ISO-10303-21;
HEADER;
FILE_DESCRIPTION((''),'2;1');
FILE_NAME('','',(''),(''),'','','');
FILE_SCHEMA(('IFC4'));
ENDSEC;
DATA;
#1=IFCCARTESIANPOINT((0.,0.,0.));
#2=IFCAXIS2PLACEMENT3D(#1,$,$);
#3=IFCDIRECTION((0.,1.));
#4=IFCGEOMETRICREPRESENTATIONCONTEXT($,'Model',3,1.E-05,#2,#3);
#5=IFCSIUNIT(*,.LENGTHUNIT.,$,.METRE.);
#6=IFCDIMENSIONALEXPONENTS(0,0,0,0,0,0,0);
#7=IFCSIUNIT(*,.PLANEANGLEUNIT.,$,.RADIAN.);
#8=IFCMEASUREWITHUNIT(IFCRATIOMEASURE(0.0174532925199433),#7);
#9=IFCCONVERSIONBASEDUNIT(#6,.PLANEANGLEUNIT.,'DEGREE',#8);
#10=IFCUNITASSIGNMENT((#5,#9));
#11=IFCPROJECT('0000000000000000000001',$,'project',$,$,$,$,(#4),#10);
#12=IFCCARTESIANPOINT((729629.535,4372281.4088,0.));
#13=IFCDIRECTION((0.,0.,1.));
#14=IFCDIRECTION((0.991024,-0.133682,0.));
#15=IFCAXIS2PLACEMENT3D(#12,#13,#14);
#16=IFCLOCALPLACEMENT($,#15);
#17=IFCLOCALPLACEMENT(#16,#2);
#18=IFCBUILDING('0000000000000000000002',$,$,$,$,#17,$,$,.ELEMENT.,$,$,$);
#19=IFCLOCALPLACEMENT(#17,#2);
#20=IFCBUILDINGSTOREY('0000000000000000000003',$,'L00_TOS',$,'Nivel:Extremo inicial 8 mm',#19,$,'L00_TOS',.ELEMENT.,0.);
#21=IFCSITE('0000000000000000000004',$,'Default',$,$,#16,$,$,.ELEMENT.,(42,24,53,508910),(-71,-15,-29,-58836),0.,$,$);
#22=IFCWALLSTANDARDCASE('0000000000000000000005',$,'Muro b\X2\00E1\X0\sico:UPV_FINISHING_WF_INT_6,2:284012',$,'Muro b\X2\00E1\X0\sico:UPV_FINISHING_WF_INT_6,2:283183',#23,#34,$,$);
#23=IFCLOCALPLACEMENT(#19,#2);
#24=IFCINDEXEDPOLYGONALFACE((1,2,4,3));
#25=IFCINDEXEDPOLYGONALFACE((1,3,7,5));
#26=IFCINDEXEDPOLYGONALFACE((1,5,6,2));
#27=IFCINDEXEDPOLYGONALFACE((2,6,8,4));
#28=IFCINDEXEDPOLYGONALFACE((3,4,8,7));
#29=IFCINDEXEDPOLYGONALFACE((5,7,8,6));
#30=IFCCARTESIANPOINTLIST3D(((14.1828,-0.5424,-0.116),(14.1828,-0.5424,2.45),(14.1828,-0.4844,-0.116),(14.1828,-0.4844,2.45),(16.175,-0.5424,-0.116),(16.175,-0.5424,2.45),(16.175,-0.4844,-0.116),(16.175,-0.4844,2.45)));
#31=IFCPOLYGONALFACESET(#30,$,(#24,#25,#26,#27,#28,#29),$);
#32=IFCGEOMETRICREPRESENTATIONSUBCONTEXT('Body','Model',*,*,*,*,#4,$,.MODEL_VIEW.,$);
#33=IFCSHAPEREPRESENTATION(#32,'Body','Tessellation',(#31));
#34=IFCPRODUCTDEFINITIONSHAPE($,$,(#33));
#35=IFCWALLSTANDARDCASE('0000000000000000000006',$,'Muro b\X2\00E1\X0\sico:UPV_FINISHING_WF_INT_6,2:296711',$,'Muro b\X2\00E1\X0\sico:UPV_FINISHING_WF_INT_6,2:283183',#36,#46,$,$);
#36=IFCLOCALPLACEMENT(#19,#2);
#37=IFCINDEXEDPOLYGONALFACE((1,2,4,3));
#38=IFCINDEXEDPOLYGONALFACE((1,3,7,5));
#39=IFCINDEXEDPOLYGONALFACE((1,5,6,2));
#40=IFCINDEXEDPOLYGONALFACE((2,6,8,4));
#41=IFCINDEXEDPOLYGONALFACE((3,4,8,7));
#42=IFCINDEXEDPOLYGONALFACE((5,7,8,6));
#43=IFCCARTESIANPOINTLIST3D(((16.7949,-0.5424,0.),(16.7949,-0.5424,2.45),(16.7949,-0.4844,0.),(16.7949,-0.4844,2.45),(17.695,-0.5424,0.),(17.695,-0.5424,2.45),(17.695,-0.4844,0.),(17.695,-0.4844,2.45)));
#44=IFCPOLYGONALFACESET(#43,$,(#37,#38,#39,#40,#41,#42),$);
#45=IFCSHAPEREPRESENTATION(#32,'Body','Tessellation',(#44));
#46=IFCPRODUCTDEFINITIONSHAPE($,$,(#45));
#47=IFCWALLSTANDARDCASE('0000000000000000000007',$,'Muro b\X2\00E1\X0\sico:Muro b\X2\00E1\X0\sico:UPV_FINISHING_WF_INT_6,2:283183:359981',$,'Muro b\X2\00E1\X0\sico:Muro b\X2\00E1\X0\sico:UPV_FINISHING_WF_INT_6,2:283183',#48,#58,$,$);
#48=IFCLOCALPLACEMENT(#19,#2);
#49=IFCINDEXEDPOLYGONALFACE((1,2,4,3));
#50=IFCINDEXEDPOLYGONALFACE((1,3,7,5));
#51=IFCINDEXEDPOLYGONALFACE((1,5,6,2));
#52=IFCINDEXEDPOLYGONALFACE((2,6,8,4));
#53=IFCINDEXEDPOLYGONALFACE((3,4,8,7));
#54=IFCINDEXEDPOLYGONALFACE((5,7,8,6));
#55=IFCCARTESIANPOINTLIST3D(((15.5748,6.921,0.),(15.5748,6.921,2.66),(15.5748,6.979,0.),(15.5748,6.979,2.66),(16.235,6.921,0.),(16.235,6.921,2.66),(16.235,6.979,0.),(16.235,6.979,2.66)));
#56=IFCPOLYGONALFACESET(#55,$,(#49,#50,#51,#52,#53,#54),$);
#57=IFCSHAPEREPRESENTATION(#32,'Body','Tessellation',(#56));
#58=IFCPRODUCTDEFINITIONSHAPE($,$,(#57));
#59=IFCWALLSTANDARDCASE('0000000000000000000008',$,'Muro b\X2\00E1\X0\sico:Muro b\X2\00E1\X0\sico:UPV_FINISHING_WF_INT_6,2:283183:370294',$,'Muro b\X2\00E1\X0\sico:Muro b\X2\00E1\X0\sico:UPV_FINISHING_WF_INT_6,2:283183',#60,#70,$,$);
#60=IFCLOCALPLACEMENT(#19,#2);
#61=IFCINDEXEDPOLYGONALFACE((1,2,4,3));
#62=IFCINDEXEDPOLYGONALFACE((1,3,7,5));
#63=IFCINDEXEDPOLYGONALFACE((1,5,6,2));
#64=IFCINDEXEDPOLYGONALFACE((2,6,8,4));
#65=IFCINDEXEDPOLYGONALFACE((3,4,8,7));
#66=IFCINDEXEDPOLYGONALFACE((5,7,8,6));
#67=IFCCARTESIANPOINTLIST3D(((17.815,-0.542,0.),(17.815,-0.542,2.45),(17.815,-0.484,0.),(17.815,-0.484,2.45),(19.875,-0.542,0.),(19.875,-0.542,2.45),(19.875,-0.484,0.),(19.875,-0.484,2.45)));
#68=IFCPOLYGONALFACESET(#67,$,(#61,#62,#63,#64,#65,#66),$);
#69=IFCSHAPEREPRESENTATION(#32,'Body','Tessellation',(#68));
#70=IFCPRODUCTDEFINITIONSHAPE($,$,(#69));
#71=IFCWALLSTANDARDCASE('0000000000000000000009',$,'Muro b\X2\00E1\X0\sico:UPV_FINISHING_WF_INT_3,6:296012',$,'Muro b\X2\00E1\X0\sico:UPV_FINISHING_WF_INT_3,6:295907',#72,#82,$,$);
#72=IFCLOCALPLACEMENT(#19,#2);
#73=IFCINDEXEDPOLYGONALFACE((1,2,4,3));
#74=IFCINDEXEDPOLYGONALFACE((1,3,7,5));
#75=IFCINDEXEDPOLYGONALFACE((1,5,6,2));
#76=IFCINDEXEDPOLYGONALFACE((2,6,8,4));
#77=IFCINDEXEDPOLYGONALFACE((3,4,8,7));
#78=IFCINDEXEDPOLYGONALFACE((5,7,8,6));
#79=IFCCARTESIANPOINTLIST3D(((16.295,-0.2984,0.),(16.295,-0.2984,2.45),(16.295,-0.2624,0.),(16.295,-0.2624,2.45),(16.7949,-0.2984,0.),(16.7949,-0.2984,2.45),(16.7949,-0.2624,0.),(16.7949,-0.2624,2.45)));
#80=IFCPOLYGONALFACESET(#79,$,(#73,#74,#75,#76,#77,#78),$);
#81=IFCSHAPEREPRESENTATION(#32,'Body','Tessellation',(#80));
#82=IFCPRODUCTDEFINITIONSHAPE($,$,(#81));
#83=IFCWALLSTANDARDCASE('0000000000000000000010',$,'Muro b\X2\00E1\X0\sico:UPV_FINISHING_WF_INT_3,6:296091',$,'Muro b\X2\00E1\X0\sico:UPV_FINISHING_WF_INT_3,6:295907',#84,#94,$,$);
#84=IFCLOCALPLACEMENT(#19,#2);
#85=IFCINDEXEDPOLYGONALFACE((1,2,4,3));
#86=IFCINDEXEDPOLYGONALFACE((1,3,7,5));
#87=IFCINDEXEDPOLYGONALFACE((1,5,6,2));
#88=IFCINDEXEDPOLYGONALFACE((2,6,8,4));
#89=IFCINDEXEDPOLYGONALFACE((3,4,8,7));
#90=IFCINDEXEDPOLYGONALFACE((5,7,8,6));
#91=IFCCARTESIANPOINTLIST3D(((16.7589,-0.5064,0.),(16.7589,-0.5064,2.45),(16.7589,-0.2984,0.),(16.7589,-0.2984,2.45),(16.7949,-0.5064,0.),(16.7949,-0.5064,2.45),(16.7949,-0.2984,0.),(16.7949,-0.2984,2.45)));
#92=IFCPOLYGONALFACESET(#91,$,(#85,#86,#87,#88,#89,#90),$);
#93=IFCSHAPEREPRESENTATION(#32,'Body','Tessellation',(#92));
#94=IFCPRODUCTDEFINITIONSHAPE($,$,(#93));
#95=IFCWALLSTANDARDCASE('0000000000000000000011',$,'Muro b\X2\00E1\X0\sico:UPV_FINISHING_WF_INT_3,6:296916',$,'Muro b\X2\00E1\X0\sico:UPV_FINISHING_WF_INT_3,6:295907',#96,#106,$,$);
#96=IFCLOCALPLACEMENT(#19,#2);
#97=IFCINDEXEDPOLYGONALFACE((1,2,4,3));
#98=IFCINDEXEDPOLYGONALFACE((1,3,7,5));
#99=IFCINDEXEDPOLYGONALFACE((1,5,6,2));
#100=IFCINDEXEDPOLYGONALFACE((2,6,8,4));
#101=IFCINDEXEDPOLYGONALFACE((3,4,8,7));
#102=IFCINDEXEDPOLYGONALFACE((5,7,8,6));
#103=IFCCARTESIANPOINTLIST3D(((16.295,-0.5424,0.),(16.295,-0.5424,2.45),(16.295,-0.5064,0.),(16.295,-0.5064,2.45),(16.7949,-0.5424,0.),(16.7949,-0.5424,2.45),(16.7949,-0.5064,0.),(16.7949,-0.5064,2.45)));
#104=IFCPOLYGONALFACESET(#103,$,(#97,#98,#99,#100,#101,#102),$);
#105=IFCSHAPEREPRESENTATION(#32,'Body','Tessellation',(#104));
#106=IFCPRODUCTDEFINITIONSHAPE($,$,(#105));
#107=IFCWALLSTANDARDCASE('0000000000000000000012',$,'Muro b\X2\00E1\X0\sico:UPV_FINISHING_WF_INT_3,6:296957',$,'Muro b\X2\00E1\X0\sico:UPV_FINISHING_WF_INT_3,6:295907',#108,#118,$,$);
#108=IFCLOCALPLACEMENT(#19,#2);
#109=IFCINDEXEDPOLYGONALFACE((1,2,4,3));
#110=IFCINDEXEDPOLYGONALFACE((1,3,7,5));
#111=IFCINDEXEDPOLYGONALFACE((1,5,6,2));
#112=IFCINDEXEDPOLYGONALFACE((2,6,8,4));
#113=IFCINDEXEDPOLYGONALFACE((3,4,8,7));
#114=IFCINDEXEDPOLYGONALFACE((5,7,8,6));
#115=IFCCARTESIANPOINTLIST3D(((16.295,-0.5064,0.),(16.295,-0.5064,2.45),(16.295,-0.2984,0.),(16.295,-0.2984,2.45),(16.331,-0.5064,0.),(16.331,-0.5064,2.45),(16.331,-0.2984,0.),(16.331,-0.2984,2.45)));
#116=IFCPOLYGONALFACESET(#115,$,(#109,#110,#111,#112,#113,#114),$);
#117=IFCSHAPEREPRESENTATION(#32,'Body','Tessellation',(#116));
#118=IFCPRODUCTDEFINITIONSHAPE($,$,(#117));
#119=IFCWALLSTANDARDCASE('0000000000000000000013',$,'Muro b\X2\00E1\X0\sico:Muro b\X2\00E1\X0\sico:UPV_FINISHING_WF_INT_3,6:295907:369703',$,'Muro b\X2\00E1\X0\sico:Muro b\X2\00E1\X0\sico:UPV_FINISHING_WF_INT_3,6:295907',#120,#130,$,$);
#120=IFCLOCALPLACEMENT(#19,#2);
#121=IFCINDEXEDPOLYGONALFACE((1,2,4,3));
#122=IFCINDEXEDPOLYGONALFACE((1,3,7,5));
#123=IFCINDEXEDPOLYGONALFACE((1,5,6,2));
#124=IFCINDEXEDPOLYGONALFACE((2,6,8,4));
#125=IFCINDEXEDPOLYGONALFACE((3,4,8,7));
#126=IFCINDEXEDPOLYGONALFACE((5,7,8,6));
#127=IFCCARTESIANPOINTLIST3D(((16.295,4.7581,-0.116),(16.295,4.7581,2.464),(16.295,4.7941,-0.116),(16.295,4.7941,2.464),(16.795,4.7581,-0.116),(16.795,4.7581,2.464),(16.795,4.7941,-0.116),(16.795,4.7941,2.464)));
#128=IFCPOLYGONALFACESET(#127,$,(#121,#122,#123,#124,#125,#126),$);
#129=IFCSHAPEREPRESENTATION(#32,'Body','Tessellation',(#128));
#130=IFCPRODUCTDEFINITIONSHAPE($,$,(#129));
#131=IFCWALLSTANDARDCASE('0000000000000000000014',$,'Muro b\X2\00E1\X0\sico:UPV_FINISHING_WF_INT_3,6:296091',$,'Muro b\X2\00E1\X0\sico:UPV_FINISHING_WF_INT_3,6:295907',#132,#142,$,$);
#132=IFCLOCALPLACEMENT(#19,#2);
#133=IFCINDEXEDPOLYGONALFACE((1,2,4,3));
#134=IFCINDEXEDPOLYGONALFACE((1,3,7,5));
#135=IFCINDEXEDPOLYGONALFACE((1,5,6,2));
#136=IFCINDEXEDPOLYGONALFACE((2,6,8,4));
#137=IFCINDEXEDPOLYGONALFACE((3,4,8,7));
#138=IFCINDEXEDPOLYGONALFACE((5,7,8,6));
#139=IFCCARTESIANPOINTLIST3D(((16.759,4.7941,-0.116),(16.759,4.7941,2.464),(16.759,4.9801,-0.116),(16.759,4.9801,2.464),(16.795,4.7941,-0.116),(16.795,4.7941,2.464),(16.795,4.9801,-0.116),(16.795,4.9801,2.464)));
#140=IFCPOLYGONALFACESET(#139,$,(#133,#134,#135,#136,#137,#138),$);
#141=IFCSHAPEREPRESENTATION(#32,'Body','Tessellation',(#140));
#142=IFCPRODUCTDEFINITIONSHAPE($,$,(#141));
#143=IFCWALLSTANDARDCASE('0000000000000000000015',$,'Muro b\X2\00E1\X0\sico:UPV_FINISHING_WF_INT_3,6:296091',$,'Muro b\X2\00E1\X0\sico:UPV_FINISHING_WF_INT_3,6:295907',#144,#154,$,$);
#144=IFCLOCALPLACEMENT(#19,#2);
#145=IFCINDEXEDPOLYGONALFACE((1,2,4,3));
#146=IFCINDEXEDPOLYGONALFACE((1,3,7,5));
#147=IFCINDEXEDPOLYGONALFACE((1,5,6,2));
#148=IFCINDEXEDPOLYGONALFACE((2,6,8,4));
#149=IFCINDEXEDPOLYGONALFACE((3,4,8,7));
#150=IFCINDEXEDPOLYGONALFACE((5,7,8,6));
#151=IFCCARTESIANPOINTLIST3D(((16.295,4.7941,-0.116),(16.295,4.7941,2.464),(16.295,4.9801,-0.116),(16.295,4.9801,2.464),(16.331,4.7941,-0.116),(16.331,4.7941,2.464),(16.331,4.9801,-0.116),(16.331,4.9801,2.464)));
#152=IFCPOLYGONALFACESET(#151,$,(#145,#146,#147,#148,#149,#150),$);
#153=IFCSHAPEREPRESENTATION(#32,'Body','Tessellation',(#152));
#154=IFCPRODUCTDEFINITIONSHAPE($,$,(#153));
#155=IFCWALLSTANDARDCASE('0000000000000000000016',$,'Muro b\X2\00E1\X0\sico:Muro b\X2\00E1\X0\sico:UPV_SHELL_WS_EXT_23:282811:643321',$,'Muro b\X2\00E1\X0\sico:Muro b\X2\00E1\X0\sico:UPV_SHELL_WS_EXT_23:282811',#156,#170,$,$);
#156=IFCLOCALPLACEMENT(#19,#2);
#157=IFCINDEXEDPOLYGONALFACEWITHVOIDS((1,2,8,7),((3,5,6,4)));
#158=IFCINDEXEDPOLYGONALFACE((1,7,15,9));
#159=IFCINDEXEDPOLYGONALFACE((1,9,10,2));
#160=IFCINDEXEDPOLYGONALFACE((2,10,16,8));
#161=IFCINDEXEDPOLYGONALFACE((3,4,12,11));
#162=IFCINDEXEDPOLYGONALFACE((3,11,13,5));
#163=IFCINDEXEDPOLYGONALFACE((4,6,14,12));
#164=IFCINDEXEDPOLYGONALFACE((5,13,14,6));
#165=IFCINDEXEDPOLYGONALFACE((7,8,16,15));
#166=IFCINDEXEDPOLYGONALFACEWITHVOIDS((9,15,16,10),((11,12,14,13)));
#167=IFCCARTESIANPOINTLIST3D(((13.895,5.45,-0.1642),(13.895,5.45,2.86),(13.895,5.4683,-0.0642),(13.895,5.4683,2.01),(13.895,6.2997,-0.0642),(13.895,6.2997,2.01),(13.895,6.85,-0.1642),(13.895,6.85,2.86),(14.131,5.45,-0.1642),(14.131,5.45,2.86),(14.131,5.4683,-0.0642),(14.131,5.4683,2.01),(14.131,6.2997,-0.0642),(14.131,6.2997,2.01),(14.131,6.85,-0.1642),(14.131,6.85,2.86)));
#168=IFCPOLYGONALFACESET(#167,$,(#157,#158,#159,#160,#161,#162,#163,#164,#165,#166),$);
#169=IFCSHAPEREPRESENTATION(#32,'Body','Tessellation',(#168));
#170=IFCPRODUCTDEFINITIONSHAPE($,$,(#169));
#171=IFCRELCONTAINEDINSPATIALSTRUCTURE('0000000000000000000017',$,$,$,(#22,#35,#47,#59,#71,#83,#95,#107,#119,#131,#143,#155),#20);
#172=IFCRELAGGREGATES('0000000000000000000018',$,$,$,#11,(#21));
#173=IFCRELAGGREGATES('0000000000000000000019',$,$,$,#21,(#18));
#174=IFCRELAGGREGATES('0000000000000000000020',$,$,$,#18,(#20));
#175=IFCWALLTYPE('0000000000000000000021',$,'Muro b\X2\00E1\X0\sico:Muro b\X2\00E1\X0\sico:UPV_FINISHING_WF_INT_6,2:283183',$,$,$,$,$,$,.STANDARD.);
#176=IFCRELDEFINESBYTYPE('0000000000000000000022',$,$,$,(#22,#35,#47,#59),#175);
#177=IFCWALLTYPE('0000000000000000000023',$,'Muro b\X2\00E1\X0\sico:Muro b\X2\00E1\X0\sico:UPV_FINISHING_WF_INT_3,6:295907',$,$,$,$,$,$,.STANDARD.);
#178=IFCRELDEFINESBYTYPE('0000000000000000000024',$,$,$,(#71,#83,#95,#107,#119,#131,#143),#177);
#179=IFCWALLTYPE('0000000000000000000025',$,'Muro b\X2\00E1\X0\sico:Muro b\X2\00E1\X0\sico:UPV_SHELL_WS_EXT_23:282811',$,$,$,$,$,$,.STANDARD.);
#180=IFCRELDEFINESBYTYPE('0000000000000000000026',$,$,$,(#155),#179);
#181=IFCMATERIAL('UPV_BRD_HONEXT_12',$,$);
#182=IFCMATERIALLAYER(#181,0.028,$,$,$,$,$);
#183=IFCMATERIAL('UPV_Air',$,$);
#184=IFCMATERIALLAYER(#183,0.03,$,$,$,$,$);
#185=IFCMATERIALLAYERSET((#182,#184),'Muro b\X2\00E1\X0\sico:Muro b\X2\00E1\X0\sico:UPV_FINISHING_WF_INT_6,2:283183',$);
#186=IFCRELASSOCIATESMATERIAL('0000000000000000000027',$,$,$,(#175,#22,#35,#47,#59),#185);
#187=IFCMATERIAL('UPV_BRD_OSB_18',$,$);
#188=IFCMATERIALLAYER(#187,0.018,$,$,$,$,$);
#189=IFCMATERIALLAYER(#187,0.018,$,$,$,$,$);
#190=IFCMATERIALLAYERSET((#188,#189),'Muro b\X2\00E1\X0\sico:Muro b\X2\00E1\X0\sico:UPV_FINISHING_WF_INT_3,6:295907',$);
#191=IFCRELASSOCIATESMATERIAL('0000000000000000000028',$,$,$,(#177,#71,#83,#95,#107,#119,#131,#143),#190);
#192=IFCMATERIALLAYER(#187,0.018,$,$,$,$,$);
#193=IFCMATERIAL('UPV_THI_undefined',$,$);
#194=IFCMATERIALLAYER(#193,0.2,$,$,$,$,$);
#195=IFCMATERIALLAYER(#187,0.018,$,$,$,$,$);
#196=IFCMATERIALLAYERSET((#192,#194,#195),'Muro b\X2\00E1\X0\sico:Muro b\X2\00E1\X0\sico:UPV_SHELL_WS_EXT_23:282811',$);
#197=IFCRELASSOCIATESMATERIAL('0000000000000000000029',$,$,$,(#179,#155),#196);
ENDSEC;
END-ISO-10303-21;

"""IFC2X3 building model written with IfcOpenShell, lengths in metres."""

from ifc_helpers import new_model, entity, si_unit, converted_unit, direction, frame, frame_2d, origin, place, context, subcontext, project, spatial, rectangle, extrude, material, layer, layer_set, layer_usage, type_object, element, save


model = new_model("IFC2X3")

# Units and contexts
model_context = context("Model", 3, precision=1e-05, world=origin(), true_north=direction((0.0, 1.0)))
body_context = subcontext(model_context, "Body", "Model", "MODEL_VIEW")
ifc_project = project(units=[si_unit("LENGTHUNIT", "METRE"), converted_unit("PLANEANGLEUNIT", "DEGREE", entity("IfcRatioMeasure", 0.0174532925199433), si_unit("PLANEANGLEUNIT", "RADIAN"), dimensions=[0, 0, 0, 0, 0, 0, 0])], contexts=[model_context])

# Site, building, storey
site_placement = place(None, frame((729629.535, 4372281.4088, 0.0), z_axis=(0.0, 0.0, 1.0), x_axis=(0.991024, -0.133682, 0.0)))
site = spatial("IfcSite", under=ifc_project, at=site_placement, Name="Default", CompositionType="ELEMENT", RefLatitude=(42, 24, 53, 508910), RefLongitude=(-71, -15, -29, -58836), RefElevation=0.0)
building_placement = place(site_placement, origin())
building = spatial("IfcBuilding", under=site, at=building_placement, CompositionType="ELEMENT")
storey_placement = place(building_placement, origin())
storey = spatial("IfcBuildingStorey", under=building, at=storey_placement, Name="L00_TOS", ObjectType="Nivel:Extremo inicial 8 mm", LongName="L00_TOS", CompositionType="ELEMENT", Elevation=0.0)

# Walls
ifc_material_1 = material(Name="UPV_BRD_HONEXT_12")
ifc_layer_1 = layer(ifc_material_1, 0.028)
ifc_material_2 = material(Name="UPV_Air")
ifc_layer_2 = layer(ifc_material_2, 0.03)
ifc_layer_set_1 = layer_set([ifc_layer_1, ifc_layer_2], Name="Muro básico:Muro básico:UPV_FINISHING_WF_INT_6,2:283183")
ifc_layer_usage_1 = layer_usage(ifc_layer_set_1, "AXIS2", "NEGATIVE", 0.029)
wall_type_1 = type_object("IfcWallType", Name="Muro básico:Muro básico:UPV_FINISHING_WF_INT_6,2:283183", PredefinedType="STANDARD", material=ifc_layer_set_1)
wall_1_placement = place(storey_placement, frame((14.1828, -0.5134, -0.116)))
element("IfcWallStandardCase", 1, at=wall_1_placement, inside=storey, type_object=wall_type_1, material=ifc_layer_usage_1, Name="Muro básico:UPV_FINISHING_WF_INT_6,2:284012", ObjectType="Muro básico:UPV_FINISHING_WF_INT_6,2:283183", context=body_context, shape_type="SweptSolid", body=[
    extrude(rectangle(XDim=1.9922, YDim=0.058, at=frame_2d((0.9961, 0.0), x_axis=(-1.0, 0.0))), origin(), (0.0, 0.0, 1.0), 2.566),
])
ifc_layer_usage_2 = layer_usage(ifc_layer_set_1, "AXIS2", "NEGATIVE", 0.029)
wall_2_placement = place(storey_placement, frame((16.7949, -0.5134, 0.0)))
element("IfcWallStandardCase", 2, at=wall_2_placement, inside=storey, type_object=wall_type_1, material=ifc_layer_usage_2, Name="Muro básico:UPV_FINISHING_WF_INT_6,2:296711", ObjectType="Muro básico:UPV_FINISHING_WF_INT_6,2:283183", context=body_context, shape_type="SweptSolid", body=[
    extrude(rectangle(XDim=0.9, YDim=0.058, at=frame_2d((0.45, 0.0), x_axis=(-1.0, 0.0))), origin(), (0.0, 0.0, 1.0), 2.45),
])
ifc_layer_usage_3 = layer_usage(ifc_layer_set_1, "AXIS2", "NEGATIVE", 0.029)
wall_3_placement = place(storey_placement, frame((16.235, 6.95, 0.0), z_axis=(0.0, 0.0, 1.0), x_axis=(-1.0, 0.0, 0.0)))
element("IfcWallStandardCase", 3, at=wall_3_placement, inside=storey, type_object=wall_type_1, material=ifc_layer_usage_3, Name="Muro básico:Muro básico:UPV_FINISHING_WF_INT_6,2:283183:359981", ObjectType="Muro básico:Muro básico:UPV_FINISHING_WF_INT_6,2:283183", context=body_context, shape_type="SweptSolid", body=[
    extrude(rectangle(XDim=0.6602, YDim=0.058, at=frame_2d((0.3301, 0.0), x_axis=(-1.0, 0.0))), origin(), (0.0, 0.0, 1.0), 2.66),
])
ifc_layer_usage_4 = layer_usage(ifc_layer_set_1, "AXIS2", "NEGATIVE", 0.029)
wall_4_placement = place(storey_placement, frame((17.815, -0.513, 0.0)))
element("IfcWallStandardCase", 4, at=wall_4_placement, inside=storey, type_object=wall_type_1, material=ifc_layer_usage_4, Name="Muro básico:Muro básico:UPV_FINISHING_WF_INT_6,2:283183:370294", ObjectType="Muro básico:Muro básico:UPV_FINISHING_WF_INT_6,2:283183", context=body_context, shape_type="SweptSolid", body=[
    extrude(rectangle(XDim=2.06, YDim=0.058, at=frame_2d((1.03, 0.0), x_axis=(-1.0, 0.0))), origin(), (0.0, 0.0, 1.0), 2.45),
])
ifc_material_3 = material(Name="UPV_BRD_OSB_18")
ifc_layer_3 = layer(ifc_material_3, 0.018)
ifc_layer_4 = layer(ifc_material_3, 0.018)
ifc_layer_set_2 = layer_set([ifc_layer_3, ifc_layer_4], Name="Muro básico:Muro básico:UPV_FINISHING_WF_INT_3,6:295907")
ifc_layer_usage_5 = layer_usage(ifc_layer_set_2, "AXIS2", "NEGATIVE", 0.018)
wall_type_2 = type_object("IfcWallType", Name="Muro básico:Muro básico:UPV_FINISHING_WF_INT_3,6:295907", PredefinedType="STANDARD", material=ifc_layer_set_2)
wall_5_placement = place(storey_placement, frame((16.295, -0.2804, 0.0)))
element("IfcWallStandardCase", 5, at=wall_5_placement, inside=storey, type_object=wall_type_2, material=ifc_layer_usage_5, Name="Muro básico:UPV_FINISHING_WF_INT_3,6:296012", ObjectType="Muro básico:UPV_FINISHING_WF_INT_3,6:295907", context=body_context, shape_type="SweptSolid", body=[
    extrude(rectangle(XDim=0.5, YDim=0.036, at=frame_2d((0.25, 0.0), x_axis=(-1.0, 0.0))), origin(), (0.0, 0.0, 1.0), 2.45),
])
ifc_layer_usage_6 = layer_usage(ifc_layer_set_2, "AXIS2", "NEGATIVE", 0.018)
wall_6_placement = place(storey_placement, frame((16.7769, -0.2984, 0.0), z_axis=(0.0, 0.0, 1.0), x_axis=(0.0, -1.0, 0.0)))
element("IfcWallStandardCase", 6, at=wall_6_placement, inside=storey, type_object=wall_type_2, material=ifc_layer_usage_6, Name="Muro básico:UPV_FINISHING_WF_INT_3,6:296091", ObjectType="Muro básico:UPV_FINISHING_WF_INT_3,6:295907", context=body_context, shape_type="SweptSolid", body=[
    extrude(rectangle(XDim=0.208, YDim=0.036, at=frame_2d((0.104, 0.0), x_axis=(-1.0, 0.0))), origin(), (0.0, 0.0, 1.0), 2.45),
])
ifc_layer_usage_7 = layer_usage(ifc_layer_set_2, "AXIS2", "NEGATIVE", 0.018)
wall_7_placement = place(storey_placement, frame((16.7949, -0.5244, 0.0), z_axis=(0.0, 0.0, 1.0), x_axis=(-1.0, 0.0, 0.0)))
element("IfcWallStandardCase", 7, at=wall_7_placement, inside=storey, type_object=wall_type_2, material=ifc_layer_usage_7, Name="Muro básico:UPV_FINISHING_WF_INT_3,6:296916", ObjectType="Muro básico:UPV_FINISHING_WF_INT_3,6:295907", context=body_context, shape_type="SweptSolid", body=[
    extrude(rectangle(XDim=0.5, YDim=0.036, at=frame_2d((0.25, 0.0), x_axis=(-1.0, 0.0))), origin(), (0.0, 0.0, 1.0), 2.45),
])
ifc_layer_usage_8 = layer_usage(ifc_layer_set_2, "AXIS2", "NEGATIVE", 0.018)
wall_8_placement = place(storey_placement, frame((16.313, -0.5064, 0.0), z_axis=(0.0, 0.0, 1.0), x_axis=(0.0, 1.0, 0.0)))
element("IfcWallStandardCase", 8, at=wall_8_placement, inside=storey, type_object=wall_type_2, material=ifc_layer_usage_8, Name="Muro básico:UPV_FINISHING_WF_INT_3,6:296957", ObjectType="Muro básico:UPV_FINISHING_WF_INT_3,6:295907", context=body_context, shape_type="SweptSolid", body=[
    extrude(rectangle(XDim=0.208, YDim=0.036, at=frame_2d((0.104, 0.0), x_axis=(-1.0, 0.0))), origin(), (0.0, 0.0, 1.0), 2.45),
])
ifc_layer_usage_9 = layer_usage(ifc_layer_set_2, "AXIS2", "NEGATIVE", 0.018)
wall_9_placement = place(storey_placement, frame((16.795, 4.7761, -0.116), z_axis=(0.0, 0.0, 1.0), x_axis=(-1.0, 0.0, 0.0)))
element("IfcWallStandardCase", 9, at=wall_9_placement, inside=storey, type_object=wall_type_2, material=ifc_layer_usage_9, Name="Muro básico:Muro básico:UPV_FINISHING_WF_INT_3,6:295907:369703", ObjectType="Muro básico:Muro básico:UPV_FINISHING_WF_INT_3,6:295907", context=body_context, shape_type="SweptSolid", body=[
    extrude(rectangle(XDim=0.5, YDim=0.036, at=frame_2d((0.25, 0.0), x_axis=(-1.0, 0.0))), origin(), (0.0, 0.0, 1.0), 2.58),
])
ifc_layer_usage_10 = layer_usage(ifc_layer_set_2, "AXIS2", "NEGATIVE", 0.018)
wall_10_placement = place(storey_placement, frame((16.777, 4.9801, -0.116), z_axis=(0.0, 0.0, 1.0), x_axis=(0.0, -1.0, 0.0)))
element("IfcWallStandardCase", 10, at=wall_10_placement, inside=storey, type_object=wall_type_2, material=ifc_layer_usage_10, Name="Muro básico:UPV_FINISHING_WF_INT_3,6:296091", ObjectType="Muro básico:UPV_FINISHING_WF_INT_3,6:295907", context=body_context, shape_type="SweptSolid", body=[
    extrude(rectangle(XDim=0.186, YDim=0.036, at=frame_2d((0.093, 0.0), x_axis=(-1.0, 0.0))), origin(), (0.0, 0.0, 1.0), 2.58),
])
ifc_layer_usage_11 = layer_usage(ifc_layer_set_2, "AXIS2", "NEGATIVE", 0.018)
wall_11_placement = place(storey_placement, frame((16.313, 4.9801, -0.116), z_axis=(0.0, 0.0, 1.0), x_axis=(0.0, -1.0, 0.0)))
element("IfcWallStandardCase", 11, at=wall_11_placement, inside=storey, type_object=wall_type_2, material=ifc_layer_usage_11, Name="Muro básico:UPV_FINISHING_WF_INT_3,6:296091", ObjectType="Muro básico:UPV_FINISHING_WF_INT_3,6:295907", context=body_context, shape_type="SweptSolid", body=[
    extrude(rectangle(XDim=0.186, YDim=0.036, at=frame_2d((0.093, 0.0), x_axis=(-1.0, 0.0))), origin(), (0.0, 0.0, 1.0), 2.58),
])

# Wall, opening
ifc_layer_5 = layer(ifc_material_3, 0.018)
ifc_material_4 = material(Name="UPV_THI_undefined")
ifc_layer_6 = layer(ifc_material_4, 0.2)
ifc_layer_7 = layer(ifc_material_3, 0.018)
ifc_layer_set_3 = layer_set([ifc_layer_5, ifc_layer_6, ifc_layer_7], Name="Muro básico:Muro básico:UPV_SHELL_WS_EXT_23:282811")
ifc_layer_usage_12 = layer_usage(ifc_layer_set_3, "AXIS2", "POSITIVE", -0.118)
wall_type_3 = type_object("IfcWallType", Name="Muro básico:Muro básico:UPV_SHELL_WS_EXT_23:282811", PredefinedType="STANDARD", material=ifc_layer_set_3)
wall_12_placement = place(storey_placement, frame((14.013, 6.85, -0.1642), z_axis=(0.0, 0.0, 1.0), x_axis=(0.0, -1.0, 0.0)))
wall_12 = element("IfcWallStandardCase", 12, at=wall_12_placement, inside=storey, type_object=wall_type_3, material=ifc_layer_usage_12, Name="Muro básico:Muro básico:UPV_SHELL_WS_EXT_23:282811:643321", ObjectType="Muro básico:Muro básico:UPV_SHELL_WS_EXT_23:282811", context=body_context, shape_type="SweptSolid", body=[
    extrude(rectangle(XDim=1.4, YDim=0.236, at=frame_2d((0.7, 0.0), x_axis=(-1.0, 0.0))), origin(), (0.0, 0.0, 1.0), 3.0242),
])
opening_placement = place(wall_12_placement, origin())
element("IfcOpeningElement", 13, at=opening_placement, cuts=wall_12, ObjectType="Opening", context=body_context, shape_type="SweptSolid", body=[
    extrude(rectangle(XDim=2.0742, YDim=0.8314, at=frame_2d((0.0, 0.0), x_axis=(0.0, 1.0))), frame((0.966, 0.118, 1.1371), z_axis=(0.0, -1.0, 0.0), x_axis=(-1.0, 0.0, 0.0)), (0.0, 0.0, 1.0), 0.236),
])

save(model, "model.ifc")
